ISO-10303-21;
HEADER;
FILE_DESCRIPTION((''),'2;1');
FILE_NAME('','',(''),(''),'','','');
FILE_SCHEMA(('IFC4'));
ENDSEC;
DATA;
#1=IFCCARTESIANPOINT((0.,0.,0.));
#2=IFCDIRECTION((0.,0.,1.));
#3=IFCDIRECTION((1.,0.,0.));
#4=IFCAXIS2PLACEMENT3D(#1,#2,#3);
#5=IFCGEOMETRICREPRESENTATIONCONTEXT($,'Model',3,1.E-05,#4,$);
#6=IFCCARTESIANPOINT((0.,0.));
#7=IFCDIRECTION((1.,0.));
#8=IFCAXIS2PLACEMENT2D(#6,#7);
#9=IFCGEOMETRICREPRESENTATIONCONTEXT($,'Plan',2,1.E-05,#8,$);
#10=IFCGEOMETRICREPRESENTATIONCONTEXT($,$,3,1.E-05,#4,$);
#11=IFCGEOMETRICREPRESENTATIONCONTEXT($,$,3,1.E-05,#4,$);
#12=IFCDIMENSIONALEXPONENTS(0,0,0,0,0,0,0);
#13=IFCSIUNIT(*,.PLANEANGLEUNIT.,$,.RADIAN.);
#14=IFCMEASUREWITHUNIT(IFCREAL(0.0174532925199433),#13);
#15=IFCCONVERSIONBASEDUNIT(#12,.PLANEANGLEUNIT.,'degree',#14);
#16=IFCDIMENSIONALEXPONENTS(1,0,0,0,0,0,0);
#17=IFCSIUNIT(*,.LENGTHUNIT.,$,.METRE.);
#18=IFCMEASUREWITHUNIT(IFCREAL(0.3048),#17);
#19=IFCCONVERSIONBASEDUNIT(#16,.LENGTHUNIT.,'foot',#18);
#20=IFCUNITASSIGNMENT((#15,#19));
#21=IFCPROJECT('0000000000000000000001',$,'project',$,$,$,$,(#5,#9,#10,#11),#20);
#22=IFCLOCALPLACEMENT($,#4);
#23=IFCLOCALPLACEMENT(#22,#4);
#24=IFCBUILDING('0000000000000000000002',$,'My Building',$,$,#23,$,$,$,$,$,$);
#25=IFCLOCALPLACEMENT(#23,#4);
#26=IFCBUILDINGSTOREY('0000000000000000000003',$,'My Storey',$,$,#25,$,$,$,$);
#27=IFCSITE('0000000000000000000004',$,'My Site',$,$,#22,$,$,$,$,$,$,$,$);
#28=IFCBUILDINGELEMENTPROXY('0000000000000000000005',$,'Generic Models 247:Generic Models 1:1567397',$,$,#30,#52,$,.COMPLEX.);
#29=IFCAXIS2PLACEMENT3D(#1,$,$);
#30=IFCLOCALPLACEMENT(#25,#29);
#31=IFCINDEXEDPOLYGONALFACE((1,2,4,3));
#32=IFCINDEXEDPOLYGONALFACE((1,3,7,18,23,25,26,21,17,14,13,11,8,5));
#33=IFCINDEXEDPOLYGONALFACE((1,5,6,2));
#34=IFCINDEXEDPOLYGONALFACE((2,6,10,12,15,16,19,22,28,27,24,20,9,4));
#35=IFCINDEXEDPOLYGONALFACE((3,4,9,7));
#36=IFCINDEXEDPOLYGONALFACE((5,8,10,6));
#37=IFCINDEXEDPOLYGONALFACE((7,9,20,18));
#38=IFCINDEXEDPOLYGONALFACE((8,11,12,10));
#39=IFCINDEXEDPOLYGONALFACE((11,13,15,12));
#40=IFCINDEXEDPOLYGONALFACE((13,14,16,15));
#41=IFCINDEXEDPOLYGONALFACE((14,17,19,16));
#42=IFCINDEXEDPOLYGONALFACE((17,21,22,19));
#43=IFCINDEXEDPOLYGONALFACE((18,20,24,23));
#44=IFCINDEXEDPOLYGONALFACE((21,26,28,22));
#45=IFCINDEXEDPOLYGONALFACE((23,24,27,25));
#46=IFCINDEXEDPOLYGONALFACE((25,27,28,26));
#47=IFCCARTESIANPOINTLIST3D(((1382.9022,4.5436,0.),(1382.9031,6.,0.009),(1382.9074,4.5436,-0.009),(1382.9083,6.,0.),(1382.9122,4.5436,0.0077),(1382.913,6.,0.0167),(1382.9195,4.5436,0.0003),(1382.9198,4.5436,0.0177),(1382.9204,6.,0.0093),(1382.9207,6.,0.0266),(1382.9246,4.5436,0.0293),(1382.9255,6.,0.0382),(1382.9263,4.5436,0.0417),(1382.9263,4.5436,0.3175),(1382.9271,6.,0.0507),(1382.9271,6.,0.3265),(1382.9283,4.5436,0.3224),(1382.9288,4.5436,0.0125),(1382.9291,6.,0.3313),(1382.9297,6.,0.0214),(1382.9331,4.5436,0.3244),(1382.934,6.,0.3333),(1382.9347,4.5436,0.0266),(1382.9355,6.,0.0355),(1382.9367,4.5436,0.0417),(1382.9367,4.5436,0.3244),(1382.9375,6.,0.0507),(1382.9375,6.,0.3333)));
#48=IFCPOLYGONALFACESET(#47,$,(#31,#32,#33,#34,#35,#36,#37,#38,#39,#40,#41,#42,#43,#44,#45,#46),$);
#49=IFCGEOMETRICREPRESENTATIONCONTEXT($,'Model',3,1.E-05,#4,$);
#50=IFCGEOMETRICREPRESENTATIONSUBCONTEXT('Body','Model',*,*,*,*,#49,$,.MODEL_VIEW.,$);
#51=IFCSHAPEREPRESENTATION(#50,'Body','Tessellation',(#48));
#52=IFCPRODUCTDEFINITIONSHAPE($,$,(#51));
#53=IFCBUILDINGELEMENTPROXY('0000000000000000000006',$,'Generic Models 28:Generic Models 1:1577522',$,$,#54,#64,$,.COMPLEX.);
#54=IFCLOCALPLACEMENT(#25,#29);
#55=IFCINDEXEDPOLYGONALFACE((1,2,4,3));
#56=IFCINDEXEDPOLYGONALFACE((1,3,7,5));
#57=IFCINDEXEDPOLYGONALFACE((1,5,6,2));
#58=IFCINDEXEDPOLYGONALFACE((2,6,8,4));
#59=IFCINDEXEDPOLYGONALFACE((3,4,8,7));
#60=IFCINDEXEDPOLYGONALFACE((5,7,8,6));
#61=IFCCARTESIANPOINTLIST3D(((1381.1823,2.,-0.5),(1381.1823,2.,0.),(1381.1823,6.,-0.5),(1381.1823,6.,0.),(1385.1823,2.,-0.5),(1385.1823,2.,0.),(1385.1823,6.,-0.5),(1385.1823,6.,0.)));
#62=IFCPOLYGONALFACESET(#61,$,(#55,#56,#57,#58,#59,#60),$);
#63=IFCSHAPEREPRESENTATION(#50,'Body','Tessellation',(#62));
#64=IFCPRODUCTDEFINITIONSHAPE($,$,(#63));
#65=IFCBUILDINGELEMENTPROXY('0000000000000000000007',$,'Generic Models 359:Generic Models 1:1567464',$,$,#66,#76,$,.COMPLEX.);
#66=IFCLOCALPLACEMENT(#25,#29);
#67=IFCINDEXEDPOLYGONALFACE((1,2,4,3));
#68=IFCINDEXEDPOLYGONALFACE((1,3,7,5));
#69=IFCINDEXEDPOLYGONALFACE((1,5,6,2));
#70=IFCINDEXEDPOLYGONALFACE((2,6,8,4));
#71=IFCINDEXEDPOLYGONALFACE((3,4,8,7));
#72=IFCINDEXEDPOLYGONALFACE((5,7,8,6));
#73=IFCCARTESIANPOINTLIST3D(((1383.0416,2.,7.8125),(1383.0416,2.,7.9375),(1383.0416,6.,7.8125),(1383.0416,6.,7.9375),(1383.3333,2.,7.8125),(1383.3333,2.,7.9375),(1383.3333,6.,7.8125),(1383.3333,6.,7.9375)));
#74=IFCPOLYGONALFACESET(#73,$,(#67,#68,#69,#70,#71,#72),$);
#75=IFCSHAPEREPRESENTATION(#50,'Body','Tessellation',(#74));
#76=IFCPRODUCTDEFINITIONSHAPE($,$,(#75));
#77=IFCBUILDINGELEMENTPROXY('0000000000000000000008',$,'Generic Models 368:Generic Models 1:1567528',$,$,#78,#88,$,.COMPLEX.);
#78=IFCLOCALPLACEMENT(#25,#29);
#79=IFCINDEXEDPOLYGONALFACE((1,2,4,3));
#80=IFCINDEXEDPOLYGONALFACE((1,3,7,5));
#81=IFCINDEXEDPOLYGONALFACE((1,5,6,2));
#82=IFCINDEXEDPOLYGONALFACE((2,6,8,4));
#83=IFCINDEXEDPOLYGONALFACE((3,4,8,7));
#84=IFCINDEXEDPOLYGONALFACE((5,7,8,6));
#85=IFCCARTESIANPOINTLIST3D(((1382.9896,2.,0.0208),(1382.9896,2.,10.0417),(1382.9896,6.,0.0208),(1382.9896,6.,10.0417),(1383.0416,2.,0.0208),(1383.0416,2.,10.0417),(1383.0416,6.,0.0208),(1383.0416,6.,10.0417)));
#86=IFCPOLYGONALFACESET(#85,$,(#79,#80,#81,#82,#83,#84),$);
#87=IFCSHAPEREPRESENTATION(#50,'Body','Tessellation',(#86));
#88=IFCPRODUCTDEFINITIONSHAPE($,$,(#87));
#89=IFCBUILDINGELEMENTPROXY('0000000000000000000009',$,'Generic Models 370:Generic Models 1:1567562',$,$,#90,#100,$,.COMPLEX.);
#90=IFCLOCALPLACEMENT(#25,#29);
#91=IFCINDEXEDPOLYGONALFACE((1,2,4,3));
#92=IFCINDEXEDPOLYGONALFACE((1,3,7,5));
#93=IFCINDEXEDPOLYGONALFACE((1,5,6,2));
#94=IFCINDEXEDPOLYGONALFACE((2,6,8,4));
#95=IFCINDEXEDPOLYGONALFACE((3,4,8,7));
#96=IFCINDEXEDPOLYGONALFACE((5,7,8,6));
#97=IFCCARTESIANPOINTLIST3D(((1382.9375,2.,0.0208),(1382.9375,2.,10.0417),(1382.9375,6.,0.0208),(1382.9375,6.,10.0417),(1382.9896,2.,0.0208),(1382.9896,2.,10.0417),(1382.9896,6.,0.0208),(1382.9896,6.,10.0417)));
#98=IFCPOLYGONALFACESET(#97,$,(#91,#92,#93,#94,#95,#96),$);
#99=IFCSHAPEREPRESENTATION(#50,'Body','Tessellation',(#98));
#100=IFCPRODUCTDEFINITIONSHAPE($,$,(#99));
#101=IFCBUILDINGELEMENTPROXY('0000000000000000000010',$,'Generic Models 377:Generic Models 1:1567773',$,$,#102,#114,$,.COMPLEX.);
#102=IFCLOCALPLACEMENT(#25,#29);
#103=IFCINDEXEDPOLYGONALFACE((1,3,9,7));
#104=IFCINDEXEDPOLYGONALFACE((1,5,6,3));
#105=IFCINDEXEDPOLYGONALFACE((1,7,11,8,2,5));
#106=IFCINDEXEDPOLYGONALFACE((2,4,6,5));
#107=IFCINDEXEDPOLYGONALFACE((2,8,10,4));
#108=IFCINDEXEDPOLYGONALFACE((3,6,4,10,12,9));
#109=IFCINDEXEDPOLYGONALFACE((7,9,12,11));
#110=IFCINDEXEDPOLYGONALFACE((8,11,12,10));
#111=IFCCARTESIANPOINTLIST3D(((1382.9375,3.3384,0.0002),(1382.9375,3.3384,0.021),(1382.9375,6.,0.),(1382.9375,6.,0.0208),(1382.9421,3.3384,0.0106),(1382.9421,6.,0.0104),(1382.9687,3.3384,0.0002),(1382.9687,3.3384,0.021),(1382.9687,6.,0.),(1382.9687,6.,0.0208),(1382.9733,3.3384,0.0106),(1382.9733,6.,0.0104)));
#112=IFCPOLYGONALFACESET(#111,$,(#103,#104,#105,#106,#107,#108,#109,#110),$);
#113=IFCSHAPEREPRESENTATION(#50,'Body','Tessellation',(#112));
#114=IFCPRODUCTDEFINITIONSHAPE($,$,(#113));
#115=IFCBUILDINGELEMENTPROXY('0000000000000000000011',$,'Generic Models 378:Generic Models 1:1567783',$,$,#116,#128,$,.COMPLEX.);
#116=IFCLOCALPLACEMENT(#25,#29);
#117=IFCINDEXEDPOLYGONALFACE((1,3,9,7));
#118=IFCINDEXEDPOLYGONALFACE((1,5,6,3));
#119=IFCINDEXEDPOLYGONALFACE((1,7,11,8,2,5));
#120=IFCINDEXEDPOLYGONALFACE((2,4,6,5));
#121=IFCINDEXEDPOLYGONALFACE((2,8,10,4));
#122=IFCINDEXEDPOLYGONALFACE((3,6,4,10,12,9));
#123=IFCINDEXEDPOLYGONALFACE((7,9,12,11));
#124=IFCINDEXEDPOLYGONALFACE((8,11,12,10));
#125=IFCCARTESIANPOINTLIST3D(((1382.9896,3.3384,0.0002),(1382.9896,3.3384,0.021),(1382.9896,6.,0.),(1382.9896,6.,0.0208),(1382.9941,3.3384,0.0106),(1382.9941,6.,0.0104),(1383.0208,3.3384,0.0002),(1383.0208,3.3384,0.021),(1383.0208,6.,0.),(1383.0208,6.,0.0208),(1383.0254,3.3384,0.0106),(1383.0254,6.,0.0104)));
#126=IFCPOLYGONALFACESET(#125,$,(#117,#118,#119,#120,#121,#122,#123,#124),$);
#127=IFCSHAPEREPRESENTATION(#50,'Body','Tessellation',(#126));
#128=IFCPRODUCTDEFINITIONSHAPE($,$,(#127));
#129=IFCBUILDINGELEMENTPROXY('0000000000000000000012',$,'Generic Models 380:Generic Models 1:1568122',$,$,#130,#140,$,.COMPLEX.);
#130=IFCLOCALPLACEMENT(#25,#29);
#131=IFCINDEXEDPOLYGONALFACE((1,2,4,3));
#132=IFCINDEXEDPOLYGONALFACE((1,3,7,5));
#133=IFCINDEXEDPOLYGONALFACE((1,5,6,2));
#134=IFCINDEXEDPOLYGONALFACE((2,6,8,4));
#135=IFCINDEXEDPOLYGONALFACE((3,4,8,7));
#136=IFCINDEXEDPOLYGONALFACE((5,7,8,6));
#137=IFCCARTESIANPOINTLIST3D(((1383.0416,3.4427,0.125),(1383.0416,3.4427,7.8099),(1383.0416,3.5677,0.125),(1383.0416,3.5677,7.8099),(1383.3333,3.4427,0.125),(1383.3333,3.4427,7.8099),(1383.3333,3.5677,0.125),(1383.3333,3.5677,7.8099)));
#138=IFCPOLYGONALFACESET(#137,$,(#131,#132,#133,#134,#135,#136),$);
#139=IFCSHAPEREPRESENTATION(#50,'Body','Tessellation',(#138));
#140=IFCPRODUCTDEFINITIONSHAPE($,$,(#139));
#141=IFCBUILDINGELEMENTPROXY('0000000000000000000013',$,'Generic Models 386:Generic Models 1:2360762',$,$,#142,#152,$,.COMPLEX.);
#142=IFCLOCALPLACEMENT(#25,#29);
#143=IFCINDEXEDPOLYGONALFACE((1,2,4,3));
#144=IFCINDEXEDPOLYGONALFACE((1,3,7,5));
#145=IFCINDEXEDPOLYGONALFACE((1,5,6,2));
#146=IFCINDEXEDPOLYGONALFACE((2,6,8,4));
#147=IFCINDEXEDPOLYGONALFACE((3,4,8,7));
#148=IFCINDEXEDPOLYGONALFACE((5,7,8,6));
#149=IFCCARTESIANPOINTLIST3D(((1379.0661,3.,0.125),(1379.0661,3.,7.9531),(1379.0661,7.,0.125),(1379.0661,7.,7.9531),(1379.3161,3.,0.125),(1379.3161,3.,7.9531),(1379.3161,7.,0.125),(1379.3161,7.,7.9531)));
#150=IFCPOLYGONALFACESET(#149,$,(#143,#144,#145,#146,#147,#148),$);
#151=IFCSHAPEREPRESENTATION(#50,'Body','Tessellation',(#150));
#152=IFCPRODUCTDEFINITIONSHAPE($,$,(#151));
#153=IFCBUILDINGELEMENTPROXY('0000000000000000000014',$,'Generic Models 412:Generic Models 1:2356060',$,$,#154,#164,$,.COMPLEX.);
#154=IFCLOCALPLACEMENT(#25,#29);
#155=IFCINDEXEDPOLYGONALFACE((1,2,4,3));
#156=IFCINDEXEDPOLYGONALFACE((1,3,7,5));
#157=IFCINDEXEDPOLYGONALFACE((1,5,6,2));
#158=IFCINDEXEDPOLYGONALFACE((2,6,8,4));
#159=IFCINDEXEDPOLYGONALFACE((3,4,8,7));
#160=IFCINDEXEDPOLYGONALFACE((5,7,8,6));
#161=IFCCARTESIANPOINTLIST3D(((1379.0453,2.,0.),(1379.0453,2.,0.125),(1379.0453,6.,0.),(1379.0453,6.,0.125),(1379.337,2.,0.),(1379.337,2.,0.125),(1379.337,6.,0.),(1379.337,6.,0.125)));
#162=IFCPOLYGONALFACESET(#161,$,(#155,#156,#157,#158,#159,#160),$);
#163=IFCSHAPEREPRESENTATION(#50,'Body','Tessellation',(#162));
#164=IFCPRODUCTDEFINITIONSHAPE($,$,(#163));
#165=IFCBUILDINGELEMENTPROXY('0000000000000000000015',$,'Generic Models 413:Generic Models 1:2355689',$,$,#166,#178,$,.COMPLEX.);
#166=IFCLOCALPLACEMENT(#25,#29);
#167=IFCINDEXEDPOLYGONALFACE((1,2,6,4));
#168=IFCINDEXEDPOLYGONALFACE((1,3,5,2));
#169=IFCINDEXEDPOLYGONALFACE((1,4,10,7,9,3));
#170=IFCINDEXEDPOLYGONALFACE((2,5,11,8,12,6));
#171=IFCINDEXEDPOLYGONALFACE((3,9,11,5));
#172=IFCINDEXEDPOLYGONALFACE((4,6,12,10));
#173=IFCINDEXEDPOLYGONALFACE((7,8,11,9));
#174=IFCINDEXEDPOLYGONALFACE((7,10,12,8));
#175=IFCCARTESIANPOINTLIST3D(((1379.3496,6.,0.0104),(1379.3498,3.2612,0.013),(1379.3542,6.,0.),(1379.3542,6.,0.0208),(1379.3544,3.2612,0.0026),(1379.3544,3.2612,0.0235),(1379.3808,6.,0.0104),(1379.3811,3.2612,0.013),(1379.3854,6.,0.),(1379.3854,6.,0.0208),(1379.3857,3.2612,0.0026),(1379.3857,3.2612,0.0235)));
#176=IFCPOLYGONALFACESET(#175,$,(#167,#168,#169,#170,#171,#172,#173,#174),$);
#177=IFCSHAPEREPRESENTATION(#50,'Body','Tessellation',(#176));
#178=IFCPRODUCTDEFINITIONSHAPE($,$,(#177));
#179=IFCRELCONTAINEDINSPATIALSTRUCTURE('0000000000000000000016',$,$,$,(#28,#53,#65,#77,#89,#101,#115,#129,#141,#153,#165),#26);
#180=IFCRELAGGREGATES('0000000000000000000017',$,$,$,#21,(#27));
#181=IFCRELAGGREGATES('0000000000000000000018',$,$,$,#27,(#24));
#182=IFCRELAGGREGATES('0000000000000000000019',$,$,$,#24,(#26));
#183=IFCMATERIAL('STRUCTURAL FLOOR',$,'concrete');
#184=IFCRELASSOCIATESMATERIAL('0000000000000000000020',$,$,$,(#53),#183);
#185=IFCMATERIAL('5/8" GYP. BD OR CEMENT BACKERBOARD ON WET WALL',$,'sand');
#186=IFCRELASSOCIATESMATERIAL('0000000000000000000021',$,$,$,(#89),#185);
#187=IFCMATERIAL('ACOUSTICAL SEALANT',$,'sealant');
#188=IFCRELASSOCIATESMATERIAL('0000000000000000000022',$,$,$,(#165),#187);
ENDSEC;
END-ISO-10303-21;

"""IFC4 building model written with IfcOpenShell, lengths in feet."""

from ifc_helpers import new_model, entity, si_unit, converted_unit, frame, origin_with_axes, origin_2d_with_axis, place, context, subcontext, project, spatial, polyline, outline, extrude, material, element, save


model = new_model("IFC4")

# Units and contexts
model_context_1 = context("Model", 3, precision=1e-05, world=origin_with_axes())
plan_context = context("Plan", 2, precision=1e-05, world=origin_2d_with_axis())
model_context_2 = context("Model", 3, precision=1e-05, world=origin_with_axes())
context_of_model_1 = context(None, 3, precision=1e-05, world=origin_with_axes())
context_of_model_2 = context(None, 3, precision=1e-05, world=origin_with_axes())
body_context = subcontext(model_context_2, "Body", "Model", "MODEL_VIEW")
ifc_project = project(units=[converted_unit("PLANEANGLEUNIT", "degree", entity("IfcReal", 0.0174532925199433), si_unit("PLANEANGLEUNIT", "RADIAN"), dimensions=[0, 0, 0, 0, 0, 0, 0]), converted_unit("LENGTHUNIT", "foot", entity("IfcReal", 0.3048), si_unit("LENGTHUNIT", "METRE"), dimensions=[1, 0, 0, 0, 0, 0, 0])], contexts=[model_context_1, plan_context, context_of_model_1, context_of_model_2])

# Site, building, storey
site_placement = place(None, origin_with_axes())
site = spatial("IfcSite", under=ifc_project, at=site_placement, Name="My Site")
building_placement = place(site_placement, origin_with_axes())
building = spatial("IfcBuilding", under=site, at=building_placement, Name="My Building")
storey_placement = place(building_placement, origin_with_axes())
storey = spatial("IfcBuildingStorey", under=building, at=storey_placement, Name="My Storey")

# Building element proxies
ifc_material_1 = material(Name="5/8\" GYP. BD OR CEMENT BACKERBOARD ON WET WALL", Category="sand")
ifc_material_2 = material(Name="STRUCTURAL FLOOR", Category="concrete")
ifc_material_3 = material(Name="ACOUSTICAL SEALANT", Category="sealant")
proxy_1_placement = place(storey_placement, frame((1382.9031, 6.0, 0.0), z_axis=(0.0, -1.0, 0.0), x_axis=(0.0, 0.0, 1.0)))
element("IfcBuildingElementProxy", 1, at=proxy_1_placement, inside=storey, Name="Generic Models 247:Generic Models 1:1567397", PredefinedType="COMPLEX", context=body_context, shape_type="SweptSolid", body=[
    extrude(outline(polyline([(-0.0624, 0.0022), (0.2134, 0.0022), (0.2183, 0.0042), (0.2203, 0.0091), (0.2203, 0.0126), (-0.0624, 0.0126), (-0.0775, 0.0106), (-0.0916, 0.0048), (-0.1037, -0.0045), (-0.113, -0.0166), (-0.104, -0.0218), (-0.0964, -0.0119), (-0.0864, -0.0042), (-0.0748, 0.0006), (-0.0624, 0.0022)])), frame((0.113, -0.0218, 0.0), z_axis=(0.0, 0.0, -1.0), x_axis=(1.0, 0.0, 0.0)), (-0.006161, -0.00058, -0.999981), 1.4564),
])
proxy_2_placement = place(storey_placement, frame((1381.1823, 6.0, -0.5), z_axis=(0.0, -1.0, 0.0), x_axis=(0.0, 0.0, 1.0)))
element("IfcBuildingElementProxy", 2, at=proxy_2_placement, inside=storey, material=ifc_material_2, Name="Generic Models 28:Generic Models 1:1577522", PredefinedType="COMPLEX", context=body_context, shape_type="SweptSolid", body=[
    extrude(outline(polyline([(-0.25, -2.0), (0.25, -2.0), (0.25, 2.0), (-0.25, 2.0), (-0.25, -2.0)])), frame((0.25, -2.0, 0.0), z_axis=(0.0, 0.0, -1.0), x_axis=(1.0, 0.0, 0.0)), (0.0, 0.0, -1.0), 4.0),
])
proxy_3_placement = place(storey_placement, frame((1383.0416, 6.0, 7.8125), z_axis=(0.0, -1.0, 0.0), x_axis=(0.0, 0.0, 1.0)))
element("IfcBuildingElementProxy", 3, at=proxy_3_placement, inside=storey, Name="Generic Models 359:Generic Models 1:1567464", PredefinedType="COMPLEX", context=body_context, shape_type="SweptSolid", body=[
    extrude(outline(polyline([(-0.1458, -0.0625), (0.1458, -0.0625), (0.1458, 0.0625), (-0.1458, 0.0625), (-0.1458, -0.0625)])), frame((0.0625, -0.1458, 0.0), z_axis=(0.0, 0.0, -1.0), x_axis=(0.0, 1.0, 0.0)), (0.0, 0.0, -1.0), 4.0),
])
proxy_4_placement = place(storey_placement, frame((1382.9896, 6.0, 0.0208), z_axis=(0.0, -1.0, 0.0), x_axis=(0.0, 0.0, 1.0)))
element("IfcBuildingElementProxy", 4, at=proxy_4_placement, inside=storey, Name="Generic Models 368:Generic Models 1:1567528", PredefinedType="COMPLEX", context=body_context, shape_type="SweptSolid", body=[
    extrude(outline(polyline([(-5.0104, -0.026), (5.0104, -0.026), (5.0104, 0.026), (-5.0104, 0.026), (-5.0104, -0.026)])), frame((5.0104, -0.026, 0.0), z_axis=(0.0, 0.0, -1.0), x_axis=(-1.0, 0.0, 0.0)), (0.0, 0.0, -1.0), 4.0),
])
proxy_5_placement = place(storey_placement, frame((1382.9375, 6.0, 0.0208), z_axis=(0.0, -1.0, 0.0), x_axis=(0.0, 0.0, 1.0)))
element("IfcBuildingElementProxy", 5, at=proxy_5_placement, inside=storey, material=ifc_material_1, Name="Generic Models 370:Generic Models 1:1567562", PredefinedType="COMPLEX", context=body_context, shape_type="SweptSolid", body=[
    extrude(outline(polyline([(-5.0104, -0.026), (5.0104, -0.026), (5.0104, 0.026), (-5.0104, 0.026), (-5.0104, -0.026)])), frame((5.0104, -0.026, 0.0), z_axis=(0.0, 0.0, -1.0), x_axis=(1.0, 0.0, 0.0)), (0.0, 0.0, -1.0), 4.0),
])
for number, where, z_axis, x_axis, name in (
    (6, (1382.9375, 6.0, 0.0), (0.0, -1.0, 0.0), (0.0, 0.0, 1.0), "Generic Models 377:Generic Models 1:1567773"),
    (7, (1382.9896, 6.0, 0.0), (0.0, -1.0, 0.0), (0.0, 0.0, 1.0), "Generic Models 378:Generic Models 1:1567783"),
):
    element("IfcBuildingElementProxy", number, at=place(storey_placement, frame(where, z_axis=z_axis, x_axis=x_axis)), inside=storey, Name=name, PredefinedType="COMPLEX", context=body_context, shape_type="SweptSolid", body=[
        extrude(outline(polyline([(0.0201, 0.0), (-0.0066, 0.0162), (-0.016, 0.0097), (-0.0175, -0.0016), (0.0093, -0.0178), (0.0107, -0.0065), (0.0201, 0.0)])), frame((0.0104, -0.0172, 0.0), z_axis=(0.0, 0.0, -1.0), x_axis=(0.51911, 0.854708, 0.0)), (0.000035, 0.000056, -1.0), 2.6616),
    ])
proxy_6_placement = place(storey_placement, frame((1383.0416, 7.4427, 0.125), z_axis=(0.0, -1.0, 0.0), x_axis=(1.0, 0.0, 0.0)))
element("IfcBuildingElementProxy", 8, at=proxy_6_placement, inside=storey, Name="Generic Models 380:Generic Models 1:1568122", PredefinedType="COMPLEX", context=body_context, shape_type="SweptSolid", body=[
    extrude(outline(polyline([(-0.1458, -3.8424), (0.1458, -3.8424), (0.1458, 3.8424), (-0.1458, 3.8424), (-0.1458, -3.8424)])), frame((0.1458, 3.8424, 3.875), z_axis=(0.0, 0.0, -1.0), x_axis=(-1.0, 0.0, 0.0)), (0.0, 0.000002, -1.0), 0.125),
])
proxy_7_placement = place(storey_placement, frame((1379.0661, 3.0, 0.125), z_axis=(0.0, 0.0, 1.0), x_axis=(0.0, 1.0, 0.0)))
element("IfcBuildingElementProxy", 9, at=proxy_7_placement, inside=storey, Name="Generic Models 386:Generic Models 1:2360762", PredefinedType="COMPLEX", context=body_context, shape_type="SweptSolid", body=[
    extrude(outline(polyline([(-2.0, -0.125), (2.0, -0.125), (2.0, 0.125), (-2.0, 0.125), (-2.0, -0.125)])), frame((2.0, -0.125, 0.0), z_axis=(0.0, 0.0, -1.0), x_axis=(-1.0, 0.0, 0.0)), (0.0, 0.0, -1.0), 7.8281),
])
proxy_8_placement = place(storey_placement, frame((1379.0453, 6.0, 0.0), z_axis=(0.0, -1.0, 0.0), x_axis=(0.0, 0.0, 1.0)))
element("IfcBuildingElementProxy", 10, at=proxy_8_placement, inside=storey, Name="Generic Models 412:Generic Models 1:2356060", PredefinedType="COMPLEX", context=body_context, shape_type="SweptSolid", body=[
    extrude(outline(polyline([(-0.0625, -0.1458), (0.0625, -0.1458), (0.0625, 0.1458), (-0.0625, 0.1458), (-0.0625, -0.1458)])), frame((0.0625, -0.1458, 0.0), z_axis=(0.0, 0.0, -1.0), x_axis=(1.0, 0.0, 0.0)), (0.0, 0.0, -1.0), 4.0),
])
proxy_9_placement = place(storey_placement, frame((1379.3497, 6.0, 0.0), z_axis=(0.0, -1.0, 0.0), x_axis=(0.0, 0.0, 1.0)))
element("IfcBuildingElementProxy", 11, at=proxy_9_placement, inside=storey, material=ifc_material_3, Name="Generic Models 413:Generic Models 1:2355689", PredefinedType="COMPLEX", context=body_context, shape_type="SweptSolid", body=[
    extrude(outline(polyline([(0.0201, 0.0), (0.0107, 0.0065), (0.0093, 0.0178), (-0.0175, 0.0016), (-0.016, -0.0097), (-0.0066, -0.0162), (0.0201, 0.0)])), frame((0.0104, -0.0186, 0.0), z_axis=(0.0, 0.0, -1.0), x_axis=(0.51911, -0.854707, 0.0)), (0.000574, -0.000772, -1.0), 2.7388),
])

save(model, "model.ifc")
